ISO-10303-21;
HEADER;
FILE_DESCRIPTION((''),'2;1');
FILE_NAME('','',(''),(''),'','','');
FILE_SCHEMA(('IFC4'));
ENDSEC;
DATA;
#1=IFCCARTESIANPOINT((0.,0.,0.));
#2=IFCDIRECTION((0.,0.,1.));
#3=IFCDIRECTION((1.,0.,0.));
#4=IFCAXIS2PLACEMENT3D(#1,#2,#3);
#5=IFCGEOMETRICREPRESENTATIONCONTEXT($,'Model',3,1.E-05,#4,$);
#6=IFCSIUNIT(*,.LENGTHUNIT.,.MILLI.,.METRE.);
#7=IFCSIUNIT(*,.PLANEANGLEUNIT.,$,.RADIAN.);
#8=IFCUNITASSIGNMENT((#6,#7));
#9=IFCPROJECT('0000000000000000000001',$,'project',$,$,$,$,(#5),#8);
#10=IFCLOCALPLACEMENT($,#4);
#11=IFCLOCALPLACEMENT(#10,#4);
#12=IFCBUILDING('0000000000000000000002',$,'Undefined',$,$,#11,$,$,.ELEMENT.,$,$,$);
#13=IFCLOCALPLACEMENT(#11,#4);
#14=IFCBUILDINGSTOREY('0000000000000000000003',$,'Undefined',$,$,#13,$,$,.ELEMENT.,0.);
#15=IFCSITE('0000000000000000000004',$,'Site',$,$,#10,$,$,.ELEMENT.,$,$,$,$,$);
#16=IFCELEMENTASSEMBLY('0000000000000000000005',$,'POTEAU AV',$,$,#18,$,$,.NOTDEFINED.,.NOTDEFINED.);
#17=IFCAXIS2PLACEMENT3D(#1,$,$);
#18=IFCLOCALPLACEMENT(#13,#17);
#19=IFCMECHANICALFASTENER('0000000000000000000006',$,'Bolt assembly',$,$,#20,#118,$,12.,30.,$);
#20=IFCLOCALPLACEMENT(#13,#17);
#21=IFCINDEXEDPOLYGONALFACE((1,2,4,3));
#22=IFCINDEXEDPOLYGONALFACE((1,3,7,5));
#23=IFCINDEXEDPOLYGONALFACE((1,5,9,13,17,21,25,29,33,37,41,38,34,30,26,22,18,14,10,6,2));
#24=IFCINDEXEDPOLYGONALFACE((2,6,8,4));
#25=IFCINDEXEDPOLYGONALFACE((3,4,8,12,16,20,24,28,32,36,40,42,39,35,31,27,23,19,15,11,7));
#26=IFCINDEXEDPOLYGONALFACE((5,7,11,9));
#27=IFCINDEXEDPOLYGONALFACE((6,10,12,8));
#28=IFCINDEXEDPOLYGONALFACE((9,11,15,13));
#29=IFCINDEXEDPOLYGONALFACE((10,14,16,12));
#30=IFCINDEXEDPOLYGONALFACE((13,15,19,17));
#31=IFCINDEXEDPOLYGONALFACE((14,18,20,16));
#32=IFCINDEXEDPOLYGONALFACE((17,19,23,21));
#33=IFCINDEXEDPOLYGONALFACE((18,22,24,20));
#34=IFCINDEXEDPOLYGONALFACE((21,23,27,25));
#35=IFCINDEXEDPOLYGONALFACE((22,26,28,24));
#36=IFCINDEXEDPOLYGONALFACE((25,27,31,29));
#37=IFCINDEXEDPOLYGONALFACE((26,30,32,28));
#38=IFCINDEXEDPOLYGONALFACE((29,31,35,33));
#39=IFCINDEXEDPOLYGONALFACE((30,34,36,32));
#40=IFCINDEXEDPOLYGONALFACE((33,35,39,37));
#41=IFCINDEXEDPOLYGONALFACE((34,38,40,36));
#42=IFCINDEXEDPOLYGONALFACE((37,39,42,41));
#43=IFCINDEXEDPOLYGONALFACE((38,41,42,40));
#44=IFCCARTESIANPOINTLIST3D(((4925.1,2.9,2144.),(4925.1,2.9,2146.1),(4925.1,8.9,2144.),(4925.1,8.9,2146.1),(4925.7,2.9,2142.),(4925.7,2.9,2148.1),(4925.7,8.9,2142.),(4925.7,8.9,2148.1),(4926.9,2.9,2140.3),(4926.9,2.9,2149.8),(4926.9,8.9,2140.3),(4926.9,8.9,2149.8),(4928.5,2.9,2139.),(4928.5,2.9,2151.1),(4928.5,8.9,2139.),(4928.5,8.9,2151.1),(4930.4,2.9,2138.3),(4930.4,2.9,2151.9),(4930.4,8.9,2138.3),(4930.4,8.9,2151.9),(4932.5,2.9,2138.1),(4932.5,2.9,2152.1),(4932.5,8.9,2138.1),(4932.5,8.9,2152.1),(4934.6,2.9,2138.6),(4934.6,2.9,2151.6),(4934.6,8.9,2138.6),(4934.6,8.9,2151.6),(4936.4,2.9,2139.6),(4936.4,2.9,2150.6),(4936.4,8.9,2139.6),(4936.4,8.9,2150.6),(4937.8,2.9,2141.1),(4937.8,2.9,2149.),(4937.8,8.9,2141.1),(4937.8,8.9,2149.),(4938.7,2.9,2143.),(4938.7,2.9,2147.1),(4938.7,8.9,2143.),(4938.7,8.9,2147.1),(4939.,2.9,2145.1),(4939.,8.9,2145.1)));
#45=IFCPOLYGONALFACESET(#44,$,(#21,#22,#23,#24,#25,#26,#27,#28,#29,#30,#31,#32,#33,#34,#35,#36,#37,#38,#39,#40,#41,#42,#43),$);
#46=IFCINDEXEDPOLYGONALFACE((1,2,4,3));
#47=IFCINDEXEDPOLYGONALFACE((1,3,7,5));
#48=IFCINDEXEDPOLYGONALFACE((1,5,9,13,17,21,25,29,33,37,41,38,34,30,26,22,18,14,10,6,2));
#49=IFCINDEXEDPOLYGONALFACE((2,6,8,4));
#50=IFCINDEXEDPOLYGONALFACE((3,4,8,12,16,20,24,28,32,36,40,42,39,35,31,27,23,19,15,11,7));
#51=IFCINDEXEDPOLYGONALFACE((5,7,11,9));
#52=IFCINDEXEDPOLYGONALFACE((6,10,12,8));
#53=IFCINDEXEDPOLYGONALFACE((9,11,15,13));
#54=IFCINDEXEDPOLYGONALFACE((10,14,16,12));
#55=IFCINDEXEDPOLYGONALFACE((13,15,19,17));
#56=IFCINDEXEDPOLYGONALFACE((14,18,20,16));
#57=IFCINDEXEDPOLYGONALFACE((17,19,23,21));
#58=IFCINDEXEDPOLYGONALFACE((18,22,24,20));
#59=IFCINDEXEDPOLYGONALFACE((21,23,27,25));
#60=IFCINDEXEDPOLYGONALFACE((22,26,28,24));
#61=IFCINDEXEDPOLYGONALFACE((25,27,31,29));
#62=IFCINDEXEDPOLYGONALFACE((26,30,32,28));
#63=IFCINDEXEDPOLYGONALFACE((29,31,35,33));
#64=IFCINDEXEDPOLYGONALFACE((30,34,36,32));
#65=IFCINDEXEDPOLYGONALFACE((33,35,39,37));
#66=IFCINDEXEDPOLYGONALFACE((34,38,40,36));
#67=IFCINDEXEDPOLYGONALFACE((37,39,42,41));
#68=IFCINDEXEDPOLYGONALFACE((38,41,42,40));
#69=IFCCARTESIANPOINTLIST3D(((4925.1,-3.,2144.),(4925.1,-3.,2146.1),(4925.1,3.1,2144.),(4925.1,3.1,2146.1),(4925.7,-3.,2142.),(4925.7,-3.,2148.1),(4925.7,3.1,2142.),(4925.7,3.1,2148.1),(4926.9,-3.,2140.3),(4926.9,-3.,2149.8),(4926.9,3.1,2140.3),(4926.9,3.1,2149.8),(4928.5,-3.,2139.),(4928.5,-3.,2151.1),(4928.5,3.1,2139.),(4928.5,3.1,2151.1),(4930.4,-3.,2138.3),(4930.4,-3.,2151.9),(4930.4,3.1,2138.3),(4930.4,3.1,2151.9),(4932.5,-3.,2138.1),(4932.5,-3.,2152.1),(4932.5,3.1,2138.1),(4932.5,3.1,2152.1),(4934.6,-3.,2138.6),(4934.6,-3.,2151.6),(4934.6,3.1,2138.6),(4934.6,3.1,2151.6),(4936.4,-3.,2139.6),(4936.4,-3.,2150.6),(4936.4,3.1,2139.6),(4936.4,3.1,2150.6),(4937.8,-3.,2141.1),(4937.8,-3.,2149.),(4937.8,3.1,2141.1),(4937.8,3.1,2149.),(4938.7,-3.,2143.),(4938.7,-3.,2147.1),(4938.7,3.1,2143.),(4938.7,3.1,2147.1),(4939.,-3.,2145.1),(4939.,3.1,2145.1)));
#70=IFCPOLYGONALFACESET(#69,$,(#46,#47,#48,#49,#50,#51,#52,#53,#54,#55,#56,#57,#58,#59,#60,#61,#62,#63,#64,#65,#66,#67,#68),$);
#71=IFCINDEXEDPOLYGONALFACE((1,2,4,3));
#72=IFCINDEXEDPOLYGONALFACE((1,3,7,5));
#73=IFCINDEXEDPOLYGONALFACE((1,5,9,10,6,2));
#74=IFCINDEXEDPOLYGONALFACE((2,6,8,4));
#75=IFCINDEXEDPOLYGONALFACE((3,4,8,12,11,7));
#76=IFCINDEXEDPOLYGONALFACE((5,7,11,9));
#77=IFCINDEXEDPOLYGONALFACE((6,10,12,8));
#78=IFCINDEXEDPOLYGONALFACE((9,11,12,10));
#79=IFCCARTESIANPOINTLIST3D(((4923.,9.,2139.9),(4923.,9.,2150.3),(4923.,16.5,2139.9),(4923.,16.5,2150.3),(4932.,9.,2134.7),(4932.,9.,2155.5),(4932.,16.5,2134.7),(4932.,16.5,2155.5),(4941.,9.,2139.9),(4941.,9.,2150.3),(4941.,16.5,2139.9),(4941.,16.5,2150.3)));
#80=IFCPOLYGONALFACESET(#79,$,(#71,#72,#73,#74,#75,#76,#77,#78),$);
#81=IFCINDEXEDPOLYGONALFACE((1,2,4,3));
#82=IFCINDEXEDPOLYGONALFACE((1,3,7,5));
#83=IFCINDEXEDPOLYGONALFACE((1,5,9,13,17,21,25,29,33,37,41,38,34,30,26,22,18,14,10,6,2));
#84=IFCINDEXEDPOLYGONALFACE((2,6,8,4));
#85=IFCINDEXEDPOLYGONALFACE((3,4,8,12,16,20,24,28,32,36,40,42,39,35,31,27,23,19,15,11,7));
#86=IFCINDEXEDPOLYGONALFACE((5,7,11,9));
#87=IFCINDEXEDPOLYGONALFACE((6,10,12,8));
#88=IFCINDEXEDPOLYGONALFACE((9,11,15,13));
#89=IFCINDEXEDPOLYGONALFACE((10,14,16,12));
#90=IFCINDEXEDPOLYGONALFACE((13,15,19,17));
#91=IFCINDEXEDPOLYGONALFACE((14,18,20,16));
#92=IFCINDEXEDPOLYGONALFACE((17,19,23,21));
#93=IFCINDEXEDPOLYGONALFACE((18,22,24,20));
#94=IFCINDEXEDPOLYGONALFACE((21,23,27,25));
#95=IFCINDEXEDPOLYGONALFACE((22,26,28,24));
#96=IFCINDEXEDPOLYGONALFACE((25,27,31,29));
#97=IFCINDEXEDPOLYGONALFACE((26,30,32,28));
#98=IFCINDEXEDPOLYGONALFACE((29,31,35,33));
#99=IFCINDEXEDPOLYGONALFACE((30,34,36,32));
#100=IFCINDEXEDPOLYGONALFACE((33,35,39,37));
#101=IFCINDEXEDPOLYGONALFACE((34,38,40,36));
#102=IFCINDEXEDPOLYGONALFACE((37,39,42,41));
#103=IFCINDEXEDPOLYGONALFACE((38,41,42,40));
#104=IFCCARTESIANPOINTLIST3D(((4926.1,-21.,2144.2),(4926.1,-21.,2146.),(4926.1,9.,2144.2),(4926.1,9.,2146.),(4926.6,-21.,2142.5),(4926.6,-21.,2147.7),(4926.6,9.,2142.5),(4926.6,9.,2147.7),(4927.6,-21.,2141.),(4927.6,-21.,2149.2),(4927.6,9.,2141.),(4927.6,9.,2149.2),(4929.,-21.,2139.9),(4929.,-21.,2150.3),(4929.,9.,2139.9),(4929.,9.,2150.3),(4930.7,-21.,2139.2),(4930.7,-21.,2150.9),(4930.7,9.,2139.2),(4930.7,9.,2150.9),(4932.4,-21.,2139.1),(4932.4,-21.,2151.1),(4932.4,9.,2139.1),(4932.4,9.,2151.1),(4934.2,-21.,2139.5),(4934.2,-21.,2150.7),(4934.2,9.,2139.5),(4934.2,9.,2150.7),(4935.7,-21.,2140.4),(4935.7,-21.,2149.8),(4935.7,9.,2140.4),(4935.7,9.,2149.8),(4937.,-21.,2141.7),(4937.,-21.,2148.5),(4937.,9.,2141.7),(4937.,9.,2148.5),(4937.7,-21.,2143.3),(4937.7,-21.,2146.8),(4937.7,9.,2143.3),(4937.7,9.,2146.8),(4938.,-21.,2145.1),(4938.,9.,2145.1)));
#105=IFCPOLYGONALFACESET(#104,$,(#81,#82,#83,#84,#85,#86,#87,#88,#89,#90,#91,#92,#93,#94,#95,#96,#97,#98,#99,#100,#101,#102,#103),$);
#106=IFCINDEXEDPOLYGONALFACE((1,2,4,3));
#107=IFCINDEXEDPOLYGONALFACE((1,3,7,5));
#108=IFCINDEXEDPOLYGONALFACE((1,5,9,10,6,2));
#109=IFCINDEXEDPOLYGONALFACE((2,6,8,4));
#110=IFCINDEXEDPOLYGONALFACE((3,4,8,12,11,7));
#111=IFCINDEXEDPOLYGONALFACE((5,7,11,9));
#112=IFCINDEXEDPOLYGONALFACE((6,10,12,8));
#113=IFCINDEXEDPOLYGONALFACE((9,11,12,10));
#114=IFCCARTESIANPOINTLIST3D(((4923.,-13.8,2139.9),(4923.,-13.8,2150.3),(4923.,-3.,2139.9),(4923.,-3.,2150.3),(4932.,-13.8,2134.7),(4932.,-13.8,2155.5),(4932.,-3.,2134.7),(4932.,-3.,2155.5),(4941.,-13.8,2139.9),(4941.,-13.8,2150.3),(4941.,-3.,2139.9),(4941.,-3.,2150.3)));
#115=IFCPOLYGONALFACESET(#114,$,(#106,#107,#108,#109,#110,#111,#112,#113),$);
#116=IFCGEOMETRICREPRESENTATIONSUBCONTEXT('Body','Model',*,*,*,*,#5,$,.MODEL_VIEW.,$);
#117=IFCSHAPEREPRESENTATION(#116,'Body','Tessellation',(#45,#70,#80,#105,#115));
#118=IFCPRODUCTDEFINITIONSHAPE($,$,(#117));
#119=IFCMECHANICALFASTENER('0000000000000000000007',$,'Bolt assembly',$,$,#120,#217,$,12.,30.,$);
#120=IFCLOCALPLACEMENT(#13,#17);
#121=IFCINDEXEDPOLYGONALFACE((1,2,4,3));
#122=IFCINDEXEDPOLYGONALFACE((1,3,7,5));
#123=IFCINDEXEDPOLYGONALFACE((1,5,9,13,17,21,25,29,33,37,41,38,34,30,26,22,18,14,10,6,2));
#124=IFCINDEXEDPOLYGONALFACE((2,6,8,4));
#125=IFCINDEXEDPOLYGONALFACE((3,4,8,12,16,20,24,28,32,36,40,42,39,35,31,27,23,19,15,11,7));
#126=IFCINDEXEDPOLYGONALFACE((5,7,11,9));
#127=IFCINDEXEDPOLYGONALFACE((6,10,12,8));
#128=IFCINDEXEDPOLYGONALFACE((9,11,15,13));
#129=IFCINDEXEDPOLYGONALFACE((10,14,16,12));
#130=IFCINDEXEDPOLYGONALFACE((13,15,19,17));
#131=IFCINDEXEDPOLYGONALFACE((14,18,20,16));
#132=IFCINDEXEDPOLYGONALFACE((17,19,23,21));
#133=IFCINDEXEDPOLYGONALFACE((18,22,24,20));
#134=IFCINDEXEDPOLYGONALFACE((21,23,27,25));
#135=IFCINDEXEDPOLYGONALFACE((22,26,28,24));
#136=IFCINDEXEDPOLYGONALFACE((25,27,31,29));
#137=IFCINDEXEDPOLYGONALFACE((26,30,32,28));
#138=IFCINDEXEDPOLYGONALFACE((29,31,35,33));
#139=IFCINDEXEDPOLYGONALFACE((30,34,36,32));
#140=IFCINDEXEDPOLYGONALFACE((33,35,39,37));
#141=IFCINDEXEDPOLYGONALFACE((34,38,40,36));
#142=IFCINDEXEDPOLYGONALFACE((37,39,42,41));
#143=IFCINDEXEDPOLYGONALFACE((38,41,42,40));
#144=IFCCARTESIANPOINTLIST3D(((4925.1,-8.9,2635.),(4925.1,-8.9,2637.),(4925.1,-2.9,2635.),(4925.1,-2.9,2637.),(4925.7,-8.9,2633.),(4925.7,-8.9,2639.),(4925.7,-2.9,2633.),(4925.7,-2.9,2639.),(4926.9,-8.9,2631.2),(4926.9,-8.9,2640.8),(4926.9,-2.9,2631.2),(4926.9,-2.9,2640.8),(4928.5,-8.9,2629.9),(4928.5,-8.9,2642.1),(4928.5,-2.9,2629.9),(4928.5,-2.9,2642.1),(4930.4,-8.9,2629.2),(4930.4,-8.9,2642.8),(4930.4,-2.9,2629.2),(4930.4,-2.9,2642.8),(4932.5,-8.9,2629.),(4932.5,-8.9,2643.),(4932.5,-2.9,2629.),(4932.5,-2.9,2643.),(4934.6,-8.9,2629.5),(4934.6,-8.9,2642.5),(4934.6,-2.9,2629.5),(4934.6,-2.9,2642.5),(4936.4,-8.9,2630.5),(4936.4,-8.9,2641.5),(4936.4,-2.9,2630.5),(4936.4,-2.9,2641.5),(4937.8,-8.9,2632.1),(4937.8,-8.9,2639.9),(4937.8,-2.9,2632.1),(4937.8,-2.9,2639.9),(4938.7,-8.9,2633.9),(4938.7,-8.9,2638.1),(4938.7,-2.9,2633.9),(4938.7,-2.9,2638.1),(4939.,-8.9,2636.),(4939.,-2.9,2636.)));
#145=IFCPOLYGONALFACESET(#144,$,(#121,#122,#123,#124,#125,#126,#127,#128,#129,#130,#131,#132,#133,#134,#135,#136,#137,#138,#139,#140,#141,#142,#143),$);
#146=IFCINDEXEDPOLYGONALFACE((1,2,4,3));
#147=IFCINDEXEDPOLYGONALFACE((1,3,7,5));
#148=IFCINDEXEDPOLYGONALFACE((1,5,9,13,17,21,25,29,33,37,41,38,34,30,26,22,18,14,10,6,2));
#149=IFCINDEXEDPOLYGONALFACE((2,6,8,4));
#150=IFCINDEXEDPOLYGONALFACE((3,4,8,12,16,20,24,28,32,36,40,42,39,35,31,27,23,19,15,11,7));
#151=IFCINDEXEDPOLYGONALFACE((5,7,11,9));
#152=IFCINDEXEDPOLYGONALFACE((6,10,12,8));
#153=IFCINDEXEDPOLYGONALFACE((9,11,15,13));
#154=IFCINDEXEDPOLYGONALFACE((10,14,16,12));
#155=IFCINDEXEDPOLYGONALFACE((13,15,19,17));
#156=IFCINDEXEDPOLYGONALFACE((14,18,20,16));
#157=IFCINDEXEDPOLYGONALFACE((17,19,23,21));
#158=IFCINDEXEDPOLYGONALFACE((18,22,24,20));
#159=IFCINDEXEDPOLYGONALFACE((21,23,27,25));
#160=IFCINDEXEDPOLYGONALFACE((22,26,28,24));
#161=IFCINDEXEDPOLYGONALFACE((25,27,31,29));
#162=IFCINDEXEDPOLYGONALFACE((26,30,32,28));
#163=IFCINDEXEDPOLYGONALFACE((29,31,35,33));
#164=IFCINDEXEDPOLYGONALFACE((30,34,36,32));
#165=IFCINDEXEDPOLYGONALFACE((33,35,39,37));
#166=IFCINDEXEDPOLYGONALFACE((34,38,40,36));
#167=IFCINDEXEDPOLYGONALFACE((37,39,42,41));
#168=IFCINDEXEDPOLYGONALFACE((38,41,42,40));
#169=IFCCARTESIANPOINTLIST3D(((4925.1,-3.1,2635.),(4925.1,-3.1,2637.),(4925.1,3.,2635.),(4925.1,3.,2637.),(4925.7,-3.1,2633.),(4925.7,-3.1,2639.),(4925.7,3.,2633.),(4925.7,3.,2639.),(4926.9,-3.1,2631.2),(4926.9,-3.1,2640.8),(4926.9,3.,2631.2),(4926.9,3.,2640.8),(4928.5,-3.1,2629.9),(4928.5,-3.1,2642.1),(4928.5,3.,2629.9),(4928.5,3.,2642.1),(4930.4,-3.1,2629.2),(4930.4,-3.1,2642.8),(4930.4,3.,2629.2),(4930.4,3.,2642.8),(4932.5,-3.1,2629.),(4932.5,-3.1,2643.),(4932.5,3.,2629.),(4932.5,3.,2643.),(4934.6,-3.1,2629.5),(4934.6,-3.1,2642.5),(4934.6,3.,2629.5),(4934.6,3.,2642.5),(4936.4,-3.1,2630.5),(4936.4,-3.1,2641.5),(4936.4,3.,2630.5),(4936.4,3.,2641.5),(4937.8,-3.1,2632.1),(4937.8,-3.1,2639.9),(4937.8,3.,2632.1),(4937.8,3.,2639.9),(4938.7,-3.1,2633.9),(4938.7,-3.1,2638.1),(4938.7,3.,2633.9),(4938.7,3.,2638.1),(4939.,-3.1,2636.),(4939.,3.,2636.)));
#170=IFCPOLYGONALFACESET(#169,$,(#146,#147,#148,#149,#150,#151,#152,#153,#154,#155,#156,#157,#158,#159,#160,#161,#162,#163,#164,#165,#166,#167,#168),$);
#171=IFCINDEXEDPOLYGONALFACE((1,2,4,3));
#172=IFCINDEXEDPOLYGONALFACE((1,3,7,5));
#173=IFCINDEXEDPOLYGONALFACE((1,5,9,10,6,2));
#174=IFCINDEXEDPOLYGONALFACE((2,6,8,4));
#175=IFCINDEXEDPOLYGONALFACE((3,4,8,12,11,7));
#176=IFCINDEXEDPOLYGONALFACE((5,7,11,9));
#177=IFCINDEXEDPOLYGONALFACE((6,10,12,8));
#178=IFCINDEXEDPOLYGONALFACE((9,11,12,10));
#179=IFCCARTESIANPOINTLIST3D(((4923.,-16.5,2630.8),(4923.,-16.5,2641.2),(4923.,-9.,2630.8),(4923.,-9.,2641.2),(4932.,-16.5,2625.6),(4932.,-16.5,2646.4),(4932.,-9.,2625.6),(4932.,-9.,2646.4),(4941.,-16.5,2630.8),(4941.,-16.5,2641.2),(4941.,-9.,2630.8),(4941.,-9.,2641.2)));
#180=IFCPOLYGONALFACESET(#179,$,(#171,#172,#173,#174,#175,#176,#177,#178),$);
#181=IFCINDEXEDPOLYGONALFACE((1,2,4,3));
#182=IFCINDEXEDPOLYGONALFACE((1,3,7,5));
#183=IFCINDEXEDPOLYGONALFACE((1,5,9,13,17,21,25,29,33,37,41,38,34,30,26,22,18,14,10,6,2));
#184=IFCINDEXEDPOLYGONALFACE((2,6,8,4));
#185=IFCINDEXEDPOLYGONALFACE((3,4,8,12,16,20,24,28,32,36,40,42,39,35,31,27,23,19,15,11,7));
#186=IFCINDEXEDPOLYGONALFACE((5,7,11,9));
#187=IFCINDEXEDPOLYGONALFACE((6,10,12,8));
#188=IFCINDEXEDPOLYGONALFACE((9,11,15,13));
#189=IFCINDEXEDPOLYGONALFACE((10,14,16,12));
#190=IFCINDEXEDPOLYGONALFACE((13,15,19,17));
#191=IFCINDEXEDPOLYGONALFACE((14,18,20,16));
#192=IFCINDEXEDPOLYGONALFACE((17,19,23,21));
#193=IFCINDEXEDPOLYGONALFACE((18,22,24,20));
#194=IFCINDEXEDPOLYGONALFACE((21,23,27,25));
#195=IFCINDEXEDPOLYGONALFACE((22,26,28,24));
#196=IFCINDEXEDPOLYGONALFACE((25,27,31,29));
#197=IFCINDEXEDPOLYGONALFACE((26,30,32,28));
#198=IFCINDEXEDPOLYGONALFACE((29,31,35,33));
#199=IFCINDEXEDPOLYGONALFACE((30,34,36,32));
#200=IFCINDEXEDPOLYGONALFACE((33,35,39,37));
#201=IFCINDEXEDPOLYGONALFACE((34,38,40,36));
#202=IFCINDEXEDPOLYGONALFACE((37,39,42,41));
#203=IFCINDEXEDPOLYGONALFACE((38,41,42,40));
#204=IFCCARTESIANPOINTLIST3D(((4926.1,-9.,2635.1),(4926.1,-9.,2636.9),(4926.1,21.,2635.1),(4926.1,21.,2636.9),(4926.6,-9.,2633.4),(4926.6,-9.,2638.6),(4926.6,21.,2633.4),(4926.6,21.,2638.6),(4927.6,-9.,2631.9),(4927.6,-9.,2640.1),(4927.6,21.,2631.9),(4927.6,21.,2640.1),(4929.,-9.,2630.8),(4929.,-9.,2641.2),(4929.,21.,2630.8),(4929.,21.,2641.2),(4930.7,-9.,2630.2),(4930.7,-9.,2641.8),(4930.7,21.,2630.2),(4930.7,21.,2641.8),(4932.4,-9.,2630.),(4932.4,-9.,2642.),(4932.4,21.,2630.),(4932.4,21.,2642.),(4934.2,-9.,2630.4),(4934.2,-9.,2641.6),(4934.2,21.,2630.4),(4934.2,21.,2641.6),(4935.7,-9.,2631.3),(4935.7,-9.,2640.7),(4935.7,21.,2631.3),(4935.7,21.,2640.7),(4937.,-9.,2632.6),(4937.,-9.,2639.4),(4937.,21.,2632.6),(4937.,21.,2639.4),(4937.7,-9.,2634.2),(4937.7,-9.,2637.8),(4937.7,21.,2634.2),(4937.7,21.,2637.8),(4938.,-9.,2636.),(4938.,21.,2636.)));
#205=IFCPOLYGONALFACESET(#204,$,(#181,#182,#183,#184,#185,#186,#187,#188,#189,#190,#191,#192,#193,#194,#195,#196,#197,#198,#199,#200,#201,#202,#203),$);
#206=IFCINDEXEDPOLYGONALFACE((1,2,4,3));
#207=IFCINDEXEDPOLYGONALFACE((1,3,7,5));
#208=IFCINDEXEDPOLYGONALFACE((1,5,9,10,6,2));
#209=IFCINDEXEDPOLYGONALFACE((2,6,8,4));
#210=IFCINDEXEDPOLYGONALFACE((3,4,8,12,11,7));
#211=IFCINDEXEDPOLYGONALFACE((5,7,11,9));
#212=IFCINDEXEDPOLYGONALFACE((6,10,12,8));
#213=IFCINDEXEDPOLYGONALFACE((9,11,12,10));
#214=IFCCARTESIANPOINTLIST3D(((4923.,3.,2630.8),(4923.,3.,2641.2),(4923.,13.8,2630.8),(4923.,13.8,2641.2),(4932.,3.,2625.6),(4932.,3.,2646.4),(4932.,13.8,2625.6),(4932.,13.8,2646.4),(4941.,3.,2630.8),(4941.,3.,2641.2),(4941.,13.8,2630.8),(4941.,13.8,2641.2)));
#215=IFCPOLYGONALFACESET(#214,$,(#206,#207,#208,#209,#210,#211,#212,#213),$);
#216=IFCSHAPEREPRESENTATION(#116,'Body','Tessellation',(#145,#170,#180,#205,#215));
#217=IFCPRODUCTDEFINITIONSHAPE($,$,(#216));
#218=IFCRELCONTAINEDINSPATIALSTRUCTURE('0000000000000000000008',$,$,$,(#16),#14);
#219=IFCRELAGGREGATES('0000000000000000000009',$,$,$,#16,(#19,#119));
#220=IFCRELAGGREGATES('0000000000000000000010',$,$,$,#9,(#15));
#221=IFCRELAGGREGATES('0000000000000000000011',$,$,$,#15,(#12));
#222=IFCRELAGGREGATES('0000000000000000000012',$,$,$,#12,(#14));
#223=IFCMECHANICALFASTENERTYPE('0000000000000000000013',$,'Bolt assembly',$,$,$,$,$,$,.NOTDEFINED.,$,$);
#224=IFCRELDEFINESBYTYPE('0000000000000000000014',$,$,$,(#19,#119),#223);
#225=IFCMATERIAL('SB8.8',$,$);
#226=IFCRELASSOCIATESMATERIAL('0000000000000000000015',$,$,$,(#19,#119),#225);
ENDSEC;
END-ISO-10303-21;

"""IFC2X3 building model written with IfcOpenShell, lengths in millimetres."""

from ifc_helpers import new_model, si_unit, frame, origin_with_axes, origin_2d_with_axis, place, context, subcontext, project, spatial, polyline, circle, outline, extrude, source, transform, mapped, material, type_object, element, aggregate, save


model = new_model("IFC2X3")

# Units and contexts
model_context = context("Model", 3, precision=1e-05, world=origin_with_axes())
body_context = subcontext(model_context, "Body", "Model", "MODEL_VIEW")
ifc_project = project(units=[si_unit("LENGTHUNIT", "METRE", prefix="MILLI"), si_unit("PLANEANGLEUNIT", "RADIAN")], contexts=[model_context])

# Site, building, storey
site_placement = place(None, origin_with_axes())
site = spatial("IfcSite", under=ifc_project, at=site_placement, Name="Site", CompositionType="ELEMENT")
building_placement = place(site_placement, origin_with_axes())
building = spatial("IfcBuilding", under=site, at=building_placement, Name="Undefined", CompositionType="ELEMENT")
storey_placement = place(building_placement, origin_with_axes())
storey = spatial("IfcBuildingStorey", under=building, at=storey_placement, Name="Undefined", CompositionType="ELEMENT", Elevation=0.0)

# Element assembly
assembly_1_placement = place(storey_placement, origin_with_axes())
assembly_1 = element("IfcElementAssembly", 1, at=assembly_1_placement, inside=storey, Name="POTEAU AV", AssemblyPlace="NOTDEFINED", PredefinedType="NOTDEFINED")

# Mechanical fasteners
ifc_material_1 = material(Name="SB8.8")
mechanical_fastener_type = type_object("IfcMechanicalFastenerType", Name="Bolt assembly")
shared_shape_1 = source(origin_with_axes(), body_context, "Body", "SweptSolid", [
    extrude(circle(Radius=7.0, at=origin_2d_with_axis()), frame((0.0, -8.9, 0.0), z_axis=(0.0, 1.0, 0.0), x_axis=(1.0, 0.0, 0.0)), (0.0, 0.0, 1.0), 6.0),
    extrude(circle(Radius=7.0, at=origin_2d_with_axis()), frame((0.0, -3.1, 0.0), z_axis=(0.0, 1.0, 0.0), x_axis=(1.0, 0.0, 0.0)), (0.0, 0.0, 1.0), 6.1),
    extrude(outline(polyline([(9.0, -5.2), (9.0, 5.2), (0.0, 10.4), (-9.0, 5.2), (-9.0, -5.2), (0.0, -10.4), (9.0, -5.2)])), frame((0.0, -16.5, 0.0), z_axis=(0.0, 1.0, 0.0), x_axis=(1.0, 0.0, 0.0)), (0.0, 0.0, 1.0), 7.5),
    extrude(circle(Radius=6.0, at=origin_2d_with_axis()), frame((0.0, -9.0, 0.0), z_axis=(0.0, 1.0, 0.0), x_axis=(1.0, 0.0, 0.0)), (0.0, 0.0, 1.0), 30.0),
    extrude(outline(polyline([(9.0, -5.2), (9.0, 5.2), (0.0, 10.4), (-9.0, 5.2), (-9.0, -5.2), (0.0, -10.4), (9.0, -5.2)])), frame((0.0, 3.0, 0.0), z_axis=(0.0, 1.0, 0.0), x_axis=(1.0, 0.0, 0.0)), (0.0, 0.0, 1.0), 10.8),
])
mechanical_fastener_1_placement = place(assembly_1_placement, frame((4932.0, 0.0, 2145.1), z_axis=(0.0, 0.0, -1.0), x_axis=(1.0, 0.0, 0.0)))
mechanical_fastener_1 = element("IfcMechanicalFastener", 2, at=mechanical_fastener_1_placement, type_object=mechanical_fastener_type, material=ifc_material_1, Name="Bolt assembly", NominalDiameter=12.0, NominalLength=30.0, context=body_context, shape_type="MappedRepresentation", body=[
    mapped(shared_shape_1, transform((0.0, 0.0, 0.0))),
])
mechanical_fastener_2_placement = place(assembly_1_placement, frame((4932.0, 0.0, 2636.0), z_axis=(0.0, 0.0, 1.0), x_axis=(1.0, 0.0, 0.0)))
mechanical_fastener_2 = element("IfcMechanicalFastener", 3, at=mechanical_fastener_2_placement, type_object=mechanical_fastener_type, material=ifc_material_1, Name="Bolt assembly", NominalDiameter=12.0, NominalLength=30.0, context=body_context, shape_type="MappedRepresentation", body=[
    mapped(shared_shape_1, transform((0.0, 0.0, 0.0))),
])
aggregate(assembly_1, [mechanical_fastener_1, mechanical_fastener_2])

save(model, "model.ifc")
